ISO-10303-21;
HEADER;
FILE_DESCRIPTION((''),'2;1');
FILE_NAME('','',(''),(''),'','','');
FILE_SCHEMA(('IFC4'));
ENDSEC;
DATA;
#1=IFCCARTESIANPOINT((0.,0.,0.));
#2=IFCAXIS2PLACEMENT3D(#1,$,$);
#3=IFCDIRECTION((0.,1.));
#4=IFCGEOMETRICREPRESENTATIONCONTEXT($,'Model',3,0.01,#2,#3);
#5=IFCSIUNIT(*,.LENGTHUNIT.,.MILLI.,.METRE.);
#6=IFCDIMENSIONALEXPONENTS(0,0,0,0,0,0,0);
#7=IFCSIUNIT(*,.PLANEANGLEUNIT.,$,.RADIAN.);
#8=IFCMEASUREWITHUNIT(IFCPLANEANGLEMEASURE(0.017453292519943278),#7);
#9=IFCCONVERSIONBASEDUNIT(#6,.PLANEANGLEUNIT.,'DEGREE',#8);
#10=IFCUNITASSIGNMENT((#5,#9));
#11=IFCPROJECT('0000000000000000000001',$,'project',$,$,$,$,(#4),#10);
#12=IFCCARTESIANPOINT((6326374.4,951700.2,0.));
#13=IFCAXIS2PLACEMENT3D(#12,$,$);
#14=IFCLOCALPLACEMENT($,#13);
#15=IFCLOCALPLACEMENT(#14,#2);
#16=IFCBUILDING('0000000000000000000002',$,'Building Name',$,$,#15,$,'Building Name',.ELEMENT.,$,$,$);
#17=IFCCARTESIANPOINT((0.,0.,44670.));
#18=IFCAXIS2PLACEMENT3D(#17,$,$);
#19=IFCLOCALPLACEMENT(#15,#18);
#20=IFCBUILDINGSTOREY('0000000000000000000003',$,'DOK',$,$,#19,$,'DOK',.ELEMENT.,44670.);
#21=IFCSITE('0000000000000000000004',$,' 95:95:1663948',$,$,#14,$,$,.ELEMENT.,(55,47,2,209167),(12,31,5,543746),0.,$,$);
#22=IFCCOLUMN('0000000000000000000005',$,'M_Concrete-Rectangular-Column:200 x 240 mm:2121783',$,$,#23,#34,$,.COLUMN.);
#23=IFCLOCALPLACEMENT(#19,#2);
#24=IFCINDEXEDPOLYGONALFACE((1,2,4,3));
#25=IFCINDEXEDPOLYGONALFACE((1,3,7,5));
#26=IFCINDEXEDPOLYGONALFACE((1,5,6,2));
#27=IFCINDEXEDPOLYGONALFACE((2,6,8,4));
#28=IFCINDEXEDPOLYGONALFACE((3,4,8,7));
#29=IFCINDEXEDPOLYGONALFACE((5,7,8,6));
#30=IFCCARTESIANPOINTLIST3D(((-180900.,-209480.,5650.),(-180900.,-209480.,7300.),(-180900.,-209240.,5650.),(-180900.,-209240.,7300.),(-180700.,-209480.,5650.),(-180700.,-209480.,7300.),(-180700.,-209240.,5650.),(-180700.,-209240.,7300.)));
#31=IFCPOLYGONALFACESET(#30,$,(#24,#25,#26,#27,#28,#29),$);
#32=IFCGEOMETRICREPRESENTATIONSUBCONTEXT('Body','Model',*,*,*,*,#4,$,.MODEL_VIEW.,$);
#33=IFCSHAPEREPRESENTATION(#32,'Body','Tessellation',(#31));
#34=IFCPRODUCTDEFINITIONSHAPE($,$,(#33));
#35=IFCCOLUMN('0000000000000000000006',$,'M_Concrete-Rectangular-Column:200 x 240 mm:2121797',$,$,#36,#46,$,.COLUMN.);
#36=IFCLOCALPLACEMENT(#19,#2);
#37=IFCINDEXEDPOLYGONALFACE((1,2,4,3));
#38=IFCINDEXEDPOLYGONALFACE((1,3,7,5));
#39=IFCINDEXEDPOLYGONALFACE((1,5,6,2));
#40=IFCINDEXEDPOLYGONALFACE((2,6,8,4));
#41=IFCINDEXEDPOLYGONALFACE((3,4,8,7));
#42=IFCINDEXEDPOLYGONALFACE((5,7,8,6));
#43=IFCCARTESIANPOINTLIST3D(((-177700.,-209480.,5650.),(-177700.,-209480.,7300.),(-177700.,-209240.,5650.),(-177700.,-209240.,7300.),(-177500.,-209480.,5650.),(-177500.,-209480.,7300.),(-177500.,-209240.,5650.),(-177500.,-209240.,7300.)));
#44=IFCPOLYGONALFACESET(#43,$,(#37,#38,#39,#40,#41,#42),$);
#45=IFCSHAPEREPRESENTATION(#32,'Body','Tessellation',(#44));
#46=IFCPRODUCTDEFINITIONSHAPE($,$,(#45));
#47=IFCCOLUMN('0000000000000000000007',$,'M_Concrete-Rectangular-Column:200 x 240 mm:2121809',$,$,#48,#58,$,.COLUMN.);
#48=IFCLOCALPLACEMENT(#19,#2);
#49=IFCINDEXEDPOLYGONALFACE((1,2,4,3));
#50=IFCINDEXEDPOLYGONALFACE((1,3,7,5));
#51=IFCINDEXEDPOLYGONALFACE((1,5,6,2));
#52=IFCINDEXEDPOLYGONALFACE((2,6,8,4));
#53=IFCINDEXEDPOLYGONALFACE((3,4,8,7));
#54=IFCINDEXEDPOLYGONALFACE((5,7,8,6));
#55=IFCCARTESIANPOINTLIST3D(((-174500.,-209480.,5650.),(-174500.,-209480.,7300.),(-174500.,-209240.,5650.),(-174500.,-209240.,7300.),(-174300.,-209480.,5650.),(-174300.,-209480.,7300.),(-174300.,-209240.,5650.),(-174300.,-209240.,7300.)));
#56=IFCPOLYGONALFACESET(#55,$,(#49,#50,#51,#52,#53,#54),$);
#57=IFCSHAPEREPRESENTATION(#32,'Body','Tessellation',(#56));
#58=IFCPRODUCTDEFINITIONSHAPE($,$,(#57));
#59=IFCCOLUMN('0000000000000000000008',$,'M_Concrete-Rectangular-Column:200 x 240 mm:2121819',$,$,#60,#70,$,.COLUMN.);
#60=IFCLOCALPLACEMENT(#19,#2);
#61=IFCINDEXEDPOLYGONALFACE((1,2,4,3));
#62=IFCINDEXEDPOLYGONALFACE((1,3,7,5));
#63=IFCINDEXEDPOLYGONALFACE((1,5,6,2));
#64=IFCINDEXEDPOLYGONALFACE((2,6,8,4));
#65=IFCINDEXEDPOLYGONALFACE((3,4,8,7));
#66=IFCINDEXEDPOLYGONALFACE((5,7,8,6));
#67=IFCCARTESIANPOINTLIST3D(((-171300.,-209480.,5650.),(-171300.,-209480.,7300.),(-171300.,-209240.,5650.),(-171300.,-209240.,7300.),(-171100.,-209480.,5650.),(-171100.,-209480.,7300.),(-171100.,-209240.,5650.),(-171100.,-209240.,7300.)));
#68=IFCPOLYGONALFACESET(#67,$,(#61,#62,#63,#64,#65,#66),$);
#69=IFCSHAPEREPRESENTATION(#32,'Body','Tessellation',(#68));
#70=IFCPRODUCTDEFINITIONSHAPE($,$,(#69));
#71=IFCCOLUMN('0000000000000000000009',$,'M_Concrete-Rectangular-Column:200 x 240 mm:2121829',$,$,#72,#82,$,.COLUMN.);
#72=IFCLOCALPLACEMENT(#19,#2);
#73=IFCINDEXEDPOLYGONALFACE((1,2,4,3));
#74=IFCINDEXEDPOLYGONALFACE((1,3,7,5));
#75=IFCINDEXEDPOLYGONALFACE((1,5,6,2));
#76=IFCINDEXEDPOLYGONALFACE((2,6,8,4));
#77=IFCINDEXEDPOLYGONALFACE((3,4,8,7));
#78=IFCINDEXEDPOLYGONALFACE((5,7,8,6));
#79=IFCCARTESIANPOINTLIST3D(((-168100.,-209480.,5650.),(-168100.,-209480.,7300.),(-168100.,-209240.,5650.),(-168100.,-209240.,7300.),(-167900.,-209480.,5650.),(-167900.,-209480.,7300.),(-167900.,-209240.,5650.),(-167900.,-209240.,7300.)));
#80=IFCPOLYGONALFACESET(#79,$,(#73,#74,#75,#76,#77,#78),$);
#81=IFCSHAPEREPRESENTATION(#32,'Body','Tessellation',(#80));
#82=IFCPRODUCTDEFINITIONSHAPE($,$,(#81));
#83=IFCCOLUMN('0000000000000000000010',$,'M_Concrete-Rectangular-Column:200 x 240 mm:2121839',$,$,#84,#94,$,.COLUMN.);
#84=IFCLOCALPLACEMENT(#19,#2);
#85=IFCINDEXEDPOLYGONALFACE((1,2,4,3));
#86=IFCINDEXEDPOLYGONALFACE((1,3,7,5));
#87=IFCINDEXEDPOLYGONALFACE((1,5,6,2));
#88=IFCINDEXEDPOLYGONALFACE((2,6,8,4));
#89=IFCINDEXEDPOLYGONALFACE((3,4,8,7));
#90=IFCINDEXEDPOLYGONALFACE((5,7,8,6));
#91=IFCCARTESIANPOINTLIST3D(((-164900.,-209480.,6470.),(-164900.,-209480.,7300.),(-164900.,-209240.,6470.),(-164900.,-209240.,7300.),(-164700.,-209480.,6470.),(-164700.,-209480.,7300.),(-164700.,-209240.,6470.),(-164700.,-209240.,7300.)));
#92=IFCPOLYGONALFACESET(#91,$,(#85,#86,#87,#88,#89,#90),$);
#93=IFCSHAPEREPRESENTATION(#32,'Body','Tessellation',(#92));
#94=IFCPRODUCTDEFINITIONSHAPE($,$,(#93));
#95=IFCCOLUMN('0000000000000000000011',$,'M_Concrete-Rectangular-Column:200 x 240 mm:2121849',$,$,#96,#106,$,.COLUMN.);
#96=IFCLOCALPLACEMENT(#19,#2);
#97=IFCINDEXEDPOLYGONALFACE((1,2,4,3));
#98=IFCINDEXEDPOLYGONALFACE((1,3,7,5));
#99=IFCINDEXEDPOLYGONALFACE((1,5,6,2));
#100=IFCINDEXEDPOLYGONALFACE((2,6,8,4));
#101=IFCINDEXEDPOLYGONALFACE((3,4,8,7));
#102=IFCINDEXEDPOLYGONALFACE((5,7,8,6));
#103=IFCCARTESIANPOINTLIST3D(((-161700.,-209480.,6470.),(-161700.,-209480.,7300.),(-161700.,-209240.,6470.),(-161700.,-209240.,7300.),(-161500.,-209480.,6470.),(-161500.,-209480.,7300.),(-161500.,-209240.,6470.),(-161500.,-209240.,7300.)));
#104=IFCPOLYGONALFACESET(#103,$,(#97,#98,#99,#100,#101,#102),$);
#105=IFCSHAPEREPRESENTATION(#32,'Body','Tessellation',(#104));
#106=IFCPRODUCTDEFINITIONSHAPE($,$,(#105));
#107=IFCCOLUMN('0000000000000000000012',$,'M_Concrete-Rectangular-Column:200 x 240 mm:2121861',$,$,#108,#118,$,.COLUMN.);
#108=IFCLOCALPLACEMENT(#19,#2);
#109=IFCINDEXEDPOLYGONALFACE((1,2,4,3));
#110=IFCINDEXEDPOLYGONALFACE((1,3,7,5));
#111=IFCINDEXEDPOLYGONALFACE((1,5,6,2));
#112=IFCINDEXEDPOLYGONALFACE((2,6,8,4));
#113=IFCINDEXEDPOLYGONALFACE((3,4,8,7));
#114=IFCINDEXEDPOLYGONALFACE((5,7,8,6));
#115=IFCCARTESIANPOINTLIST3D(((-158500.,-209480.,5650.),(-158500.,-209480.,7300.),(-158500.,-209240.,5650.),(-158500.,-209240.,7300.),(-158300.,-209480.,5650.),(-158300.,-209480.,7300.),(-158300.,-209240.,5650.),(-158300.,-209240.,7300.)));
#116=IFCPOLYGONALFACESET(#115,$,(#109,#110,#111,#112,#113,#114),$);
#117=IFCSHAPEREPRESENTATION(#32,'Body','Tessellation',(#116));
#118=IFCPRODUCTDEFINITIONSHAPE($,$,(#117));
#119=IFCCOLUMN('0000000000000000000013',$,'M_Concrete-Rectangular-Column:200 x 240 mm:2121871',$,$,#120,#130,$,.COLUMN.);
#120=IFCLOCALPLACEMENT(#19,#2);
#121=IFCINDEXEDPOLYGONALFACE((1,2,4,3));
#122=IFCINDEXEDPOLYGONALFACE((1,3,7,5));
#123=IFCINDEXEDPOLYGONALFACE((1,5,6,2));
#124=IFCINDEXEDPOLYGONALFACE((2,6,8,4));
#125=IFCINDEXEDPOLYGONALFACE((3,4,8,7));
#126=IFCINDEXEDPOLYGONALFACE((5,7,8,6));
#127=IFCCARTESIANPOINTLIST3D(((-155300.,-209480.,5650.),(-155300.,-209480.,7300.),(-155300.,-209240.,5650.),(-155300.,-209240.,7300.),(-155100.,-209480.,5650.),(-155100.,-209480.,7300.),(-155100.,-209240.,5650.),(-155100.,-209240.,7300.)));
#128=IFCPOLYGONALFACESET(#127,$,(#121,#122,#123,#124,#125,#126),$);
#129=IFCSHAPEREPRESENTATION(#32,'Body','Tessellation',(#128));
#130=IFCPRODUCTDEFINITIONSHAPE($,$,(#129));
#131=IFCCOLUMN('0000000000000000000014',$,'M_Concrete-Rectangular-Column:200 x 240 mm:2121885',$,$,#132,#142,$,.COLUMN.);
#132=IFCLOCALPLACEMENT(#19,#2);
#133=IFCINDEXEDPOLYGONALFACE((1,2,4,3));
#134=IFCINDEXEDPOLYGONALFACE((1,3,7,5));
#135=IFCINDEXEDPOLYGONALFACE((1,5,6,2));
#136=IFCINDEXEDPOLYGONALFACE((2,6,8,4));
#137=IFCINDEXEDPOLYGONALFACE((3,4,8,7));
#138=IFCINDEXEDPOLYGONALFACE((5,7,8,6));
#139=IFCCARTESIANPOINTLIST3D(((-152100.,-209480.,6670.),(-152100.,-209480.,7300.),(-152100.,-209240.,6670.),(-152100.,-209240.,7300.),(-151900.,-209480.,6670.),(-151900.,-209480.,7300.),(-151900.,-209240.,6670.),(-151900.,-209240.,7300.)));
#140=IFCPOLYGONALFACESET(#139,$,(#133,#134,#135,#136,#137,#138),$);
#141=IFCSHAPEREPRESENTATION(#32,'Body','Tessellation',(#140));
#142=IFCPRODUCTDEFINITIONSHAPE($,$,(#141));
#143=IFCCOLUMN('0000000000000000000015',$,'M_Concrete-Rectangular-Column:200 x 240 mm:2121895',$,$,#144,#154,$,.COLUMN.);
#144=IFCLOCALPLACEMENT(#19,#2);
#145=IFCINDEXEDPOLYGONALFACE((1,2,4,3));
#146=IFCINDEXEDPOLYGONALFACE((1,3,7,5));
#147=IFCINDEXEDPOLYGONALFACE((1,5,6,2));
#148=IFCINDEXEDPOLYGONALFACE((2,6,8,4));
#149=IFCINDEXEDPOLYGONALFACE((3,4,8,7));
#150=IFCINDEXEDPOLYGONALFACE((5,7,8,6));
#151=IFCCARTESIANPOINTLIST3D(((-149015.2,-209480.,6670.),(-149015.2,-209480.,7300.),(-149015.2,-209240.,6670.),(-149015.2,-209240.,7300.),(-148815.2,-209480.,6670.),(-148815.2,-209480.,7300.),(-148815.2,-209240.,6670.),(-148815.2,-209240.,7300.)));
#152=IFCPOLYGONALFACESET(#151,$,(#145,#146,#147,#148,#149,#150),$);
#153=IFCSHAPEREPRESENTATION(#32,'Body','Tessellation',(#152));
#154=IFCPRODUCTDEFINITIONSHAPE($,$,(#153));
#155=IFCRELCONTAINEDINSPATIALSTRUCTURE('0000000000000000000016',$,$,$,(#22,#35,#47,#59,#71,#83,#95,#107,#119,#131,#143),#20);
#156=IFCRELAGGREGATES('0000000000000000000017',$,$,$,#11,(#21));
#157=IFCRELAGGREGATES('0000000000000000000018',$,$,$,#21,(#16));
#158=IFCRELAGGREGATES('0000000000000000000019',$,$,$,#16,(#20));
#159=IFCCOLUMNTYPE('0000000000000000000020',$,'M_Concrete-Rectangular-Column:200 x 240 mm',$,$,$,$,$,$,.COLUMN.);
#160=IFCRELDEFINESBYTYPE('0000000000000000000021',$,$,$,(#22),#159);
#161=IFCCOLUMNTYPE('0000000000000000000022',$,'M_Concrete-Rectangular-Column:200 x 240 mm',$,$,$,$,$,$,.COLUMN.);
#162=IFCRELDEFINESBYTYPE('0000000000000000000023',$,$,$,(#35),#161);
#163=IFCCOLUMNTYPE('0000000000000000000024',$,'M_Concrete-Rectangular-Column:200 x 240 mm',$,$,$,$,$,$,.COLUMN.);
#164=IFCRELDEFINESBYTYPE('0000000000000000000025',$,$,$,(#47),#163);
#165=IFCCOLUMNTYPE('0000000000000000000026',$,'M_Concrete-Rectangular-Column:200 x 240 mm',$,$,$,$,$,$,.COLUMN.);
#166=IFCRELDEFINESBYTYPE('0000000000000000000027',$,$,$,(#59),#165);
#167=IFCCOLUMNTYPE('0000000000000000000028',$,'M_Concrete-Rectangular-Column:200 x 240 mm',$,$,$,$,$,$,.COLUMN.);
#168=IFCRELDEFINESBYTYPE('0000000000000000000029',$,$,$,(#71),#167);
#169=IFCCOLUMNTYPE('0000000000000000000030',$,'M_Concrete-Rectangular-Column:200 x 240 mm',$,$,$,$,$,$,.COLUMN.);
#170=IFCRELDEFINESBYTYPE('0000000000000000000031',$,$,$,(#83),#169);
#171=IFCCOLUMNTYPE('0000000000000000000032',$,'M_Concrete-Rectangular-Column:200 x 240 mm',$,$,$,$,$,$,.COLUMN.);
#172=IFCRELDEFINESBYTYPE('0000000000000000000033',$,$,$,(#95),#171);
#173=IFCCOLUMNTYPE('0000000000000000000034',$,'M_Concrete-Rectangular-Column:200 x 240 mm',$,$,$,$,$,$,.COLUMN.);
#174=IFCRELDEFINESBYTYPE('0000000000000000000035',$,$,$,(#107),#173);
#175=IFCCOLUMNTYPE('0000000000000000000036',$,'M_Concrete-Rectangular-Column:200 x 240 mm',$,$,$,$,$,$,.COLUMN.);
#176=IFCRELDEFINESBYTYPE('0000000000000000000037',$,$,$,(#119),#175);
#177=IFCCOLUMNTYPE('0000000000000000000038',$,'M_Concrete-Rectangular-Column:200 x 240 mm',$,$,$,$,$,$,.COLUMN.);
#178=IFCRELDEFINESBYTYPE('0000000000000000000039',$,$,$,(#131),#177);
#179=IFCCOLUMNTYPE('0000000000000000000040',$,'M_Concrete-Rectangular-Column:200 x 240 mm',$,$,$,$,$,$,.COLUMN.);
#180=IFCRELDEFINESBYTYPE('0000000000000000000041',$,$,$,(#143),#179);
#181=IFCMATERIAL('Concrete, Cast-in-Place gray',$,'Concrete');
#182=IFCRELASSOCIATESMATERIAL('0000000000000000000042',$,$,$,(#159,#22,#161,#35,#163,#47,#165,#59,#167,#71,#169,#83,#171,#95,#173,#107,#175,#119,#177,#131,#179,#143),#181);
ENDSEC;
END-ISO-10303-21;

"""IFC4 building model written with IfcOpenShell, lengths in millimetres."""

from ifc_helpers import new_model, entity, si_unit, converted_unit, direction, frame, origin, place, context, subcontext, project, spatial, indexed_curve, outline, extrude, source, transform, mapped, material, type_object, type_shapes, element, save


model = new_model("IFC4")

# Units and contexts
model_context = context("Model", 3, precision=0.01, world=origin(), true_north=direction((0.0, 1.0)))
body_context = subcontext(model_context, "Body", "Model", "MODEL_VIEW")
ifc_project = project(units=[si_unit("LENGTHUNIT", "METRE", prefix="MILLI"), converted_unit("PLANEANGLEUNIT", "DEGREE", entity("IfcPlaneAngleMeasure", 0.017453292519943278), si_unit("PLANEANGLEUNIT", "RADIAN"), dimensions=[0, 0, 0, 0, 0, 0, 0])], contexts=[model_context])

# Site, building, storey
site_placement = place(None, frame((6326374.4, 951700.2, 0.0)))
site = spatial("IfcSite", under=ifc_project, at=site_placement, Name=" 95:95:1663948", CompositionType="ELEMENT", RefLatitude=(55, 47, 2, 209167), RefLongitude=(12, 31, 5, 543746), RefElevation=0.0)
building_placement = place(site_placement, origin())
building = spatial("IfcBuilding", under=site, at=building_placement, Name="Building Name", LongName="Building Name", CompositionType="ELEMENT")
storey_placement = place(building_placement, frame((0.0, 0.0, 44670.0)))
storey = spatial("IfcBuildingStorey", under=building, at=storey_placement, Name="DOK", LongName="DOK", CompositionType="ELEMENT", Elevation=44670.0)

# Columns
ifc_material = material(Name="Concrete, Cast-in-Place gray", Category="Concrete")
column_type_1 = type_object("IfcColumnType", Name="M_Concrete-Rectangular-Column:200 x 240 mm", PredefinedType="COLUMN", material=ifc_material)
shared_shape_1 = source(origin(), body_context, "Body", "SweptSolid", [
    extrude(outline(indexed_curve([(-100.0, -120.0), (100.0, -120.0), (100.0, 120.0), (-100.0, 120.0), (-100.0, -120.0)], self_intersect=False)), frame((-180800.0, -209360.0, 50320.0), z_axis=(0.0, 0.0, 1.0), x_axis=(-1.0, 0.0, 0.0)), (0.0, 0.0, 1.0), 1650.0),
])
type_shapes(column_type_1, [shared_shape_1])
column_1_placement = place(storey_placement, frame((0.0, 0.0, -44670.0)))
element("IfcColumn", 1, at=column_1_placement, inside=storey, type_object=column_type_1, material=ifc_material, Name="M_Concrete-Rectangular-Column:200 x 240 mm:2121783", PredefinedType="COLUMN", context=body_context, shape_type="MappedRepresentation", body=[
    mapped(shared_shape_1, transform((0.0, 0.0, 0.0), scale=1.0)),
])
column_type_2 = type_object("IfcColumnType", Name="M_Concrete-Rectangular-Column:200 x 240 mm", PredefinedType="COLUMN", material=ifc_material)
shared_shape_2 = source(origin(), body_context, "Body", "SweptSolid", [
    extrude(outline(indexed_curve([(-100.0, -120.0), (100.0, -120.0), (100.0, 120.0), (-100.0, 120.0), (-100.0, -120.0)], self_intersect=False)), frame((-177600.0, -209360.0, 50320.0), z_axis=(0.0, 0.0, 1.0), x_axis=(-1.0, 0.0, 0.0)), (0.0, 0.0, 1.0), 1650.0),
])
type_shapes(column_type_2, [shared_shape_2])
column_2_placement = place(storey_placement, frame((0.0, 0.0, -44670.0)))
element("IfcColumn", 2, at=column_2_placement, inside=storey, type_object=column_type_2, material=ifc_material, Name="M_Concrete-Rectangular-Column:200 x 240 mm:2121797", PredefinedType="COLUMN", context=body_context, shape_type="MappedRepresentation", body=[
    mapped(shared_shape_2, transform((0.0, 0.0, 0.0), scale=1.0)),
])
column_type_3 = type_object("IfcColumnType", Name="M_Concrete-Rectangular-Column:200 x 240 mm", PredefinedType="COLUMN", material=ifc_material)
shared_shape_3 = source(origin(), body_context, "Body", "SweptSolid", [
    extrude(outline(indexed_curve([(-100.0, -120.0), (100.0, -120.0), (100.0, 120.0), (-100.0, 120.0), (-100.0, -120.0)], self_intersect=False)), frame((-174400.0, -209360.0, 50320.0), z_axis=(0.0, 0.0, 1.0), x_axis=(-1.0, 0.0, 0.0)), (0.0, 0.0, 1.0), 1650.0),
])
type_shapes(column_type_3, [shared_shape_3])
column_3_placement = place(storey_placement, frame((0.0, 0.0, -44670.0)))
element("IfcColumn", 3, at=column_3_placement, inside=storey, type_object=column_type_3, material=ifc_material, Name="M_Concrete-Rectangular-Column:200 x 240 mm:2121809", PredefinedType="COLUMN", context=body_context, shape_type="MappedRepresentation", body=[
    mapped(shared_shape_3, transform((0.0, 0.0, 0.0), scale=1.0)),
])
column_type_4 = type_object("IfcColumnType", Name="M_Concrete-Rectangular-Column:200 x 240 mm", PredefinedType="COLUMN", material=ifc_material)
shared_shape_4 = source(origin(), body_context, "Body", "SweptSolid", [
    extrude(outline(indexed_curve([(-100.0, -120.0), (100.0, -120.0), (100.0, 120.0), (-100.0, 120.0), (-100.0, -120.0)], self_intersect=False)), frame((-171200.0, -209360.0, 50320.0), z_axis=(0.0, 0.0, 1.0), x_axis=(-1.0, 0.0, 0.0)), (0.0, 0.0, 1.0), 1650.0),
])
type_shapes(column_type_4, [shared_shape_4])
column_4_placement = place(storey_placement, frame((0.0, 0.0, -44670.0)))
element("IfcColumn", 4, at=column_4_placement, inside=storey, type_object=column_type_4, material=ifc_material, Name="M_Concrete-Rectangular-Column:200 x 240 mm:2121819", PredefinedType="COLUMN", context=body_context, shape_type="MappedRepresentation", body=[
    mapped(shared_shape_4, transform((0.0, 0.0, 0.0), scale=1.0)),
])
column_type_5 = type_object("IfcColumnType", Name="M_Concrete-Rectangular-Column:200 x 240 mm", PredefinedType="COLUMN", material=ifc_material)
shared_shape_5 = source(origin(), body_context, "Body", "SweptSolid", [
    extrude(outline(indexed_curve([(-100.0, -120.0), (100.0, -120.0), (100.0, 120.0), (-100.0, 120.0), (-100.0, -120.0)], self_intersect=False)), frame((-168000.0, -209360.0, 50320.0), z_axis=(0.0, 0.0, 1.0), x_axis=(-1.0, 0.0, 0.0)), (0.0, 0.0, 1.0), 1650.0),
])
type_shapes(column_type_5, [shared_shape_5])
column_5_placement = place(storey_placement, frame((0.0, 0.0, -44670.0)))
element("IfcColumn", 5, at=column_5_placement, inside=storey, type_object=column_type_5, material=ifc_material, Name="M_Concrete-Rectangular-Column:200 x 240 mm:2121829", PredefinedType="COLUMN", context=body_context, shape_type="MappedRepresentation", body=[
    mapped(shared_shape_5, transform((0.0, 0.0, 0.0), scale=1.0)),
])
column_type_6 = type_object("IfcColumnType", Name="M_Concrete-Rectangular-Column:200 x 240 mm", PredefinedType="COLUMN", material=ifc_material)
shared_shape_6 = source(origin(), body_context, "Body", "SweptSolid", [
    extrude(outline(indexed_curve([(-100.0, -120.0), (100.0, -120.0), (100.0, 120.0), (-100.0, 120.0), (-100.0, -120.0)], self_intersect=False)), frame((-164800.0, -209360.0, 51140.0), z_axis=(0.0, 0.0, 1.0), x_axis=(-1.0, 0.0, 0.0)), (0.0, 0.0, 1.0), 830.0),
])
type_shapes(column_type_6, [shared_shape_6])
column_6_placement = place(storey_placement, frame((0.0, 0.0, -44670.0)))
element("IfcColumn", 6, at=column_6_placement, inside=storey, type_object=column_type_6, material=ifc_material, Name="M_Concrete-Rectangular-Column:200 x 240 mm:2121839", PredefinedType="COLUMN", context=body_context, shape_type="MappedRepresentation", body=[
    mapped(shared_shape_6, transform((0.0, 0.0, 0.0), scale=1.0)),
])
column_type_7 = type_object("IfcColumnType", Name="M_Concrete-Rectangular-Column:200 x 240 mm", PredefinedType="COLUMN", material=ifc_material)
shared_shape_7 = source(origin(), body_context, "Body", "SweptSolid", [
    extrude(outline(indexed_curve([(-100.0, -120.0), (100.0, -120.0), (100.0, 120.0), (-100.0, 120.0), (-100.0, -120.0)], self_intersect=False)), frame((-161600.0, -209360.0, 51140.0), z_axis=(0.0, 0.0, 1.0), x_axis=(-1.0, 0.0, 0.0)), (0.0, 0.0, 1.0), 830.0),
])
type_shapes(column_type_7, [shared_shape_7])
column_7_placement = place(storey_placement, frame((0.0, 0.0, -44670.0)))
element("IfcColumn", 7, at=column_7_placement, inside=storey, type_object=column_type_7, material=ifc_material, Name="M_Concrete-Rectangular-Column:200 x 240 mm:2121849", PredefinedType="COLUMN", context=body_context, shape_type="MappedRepresentation", body=[
    mapped(shared_shape_7, transform((0.0, 0.0, 0.0), scale=1.0)),
])
column_type_8 = type_object("IfcColumnType", Name="M_Concrete-Rectangular-Column:200 x 240 mm", PredefinedType="COLUMN", material=ifc_material)
shared_shape_8 = source(origin(), body_context, "Body", "SweptSolid", [
    extrude(outline(indexed_curve([(-100.0, -120.0), (100.0, -120.0), (100.0, 120.0), (-100.0, 120.0), (-100.0, -120.0)], self_intersect=False)), frame((-158400.0, -209360.0, 50320.0), z_axis=(0.0, 0.0, 1.0), x_axis=(-1.0, 0.0, 0.0)), (0.0, 0.0, 1.0), 1650.0),
])
type_shapes(column_type_8, [shared_shape_8])
column_8_placement = place(storey_placement, frame((0.0, 0.0, -44670.0)))
element("IfcColumn", 8, at=column_8_placement, inside=storey, type_object=column_type_8, material=ifc_material, Name="M_Concrete-Rectangular-Column:200 x 240 mm:2121861", PredefinedType="COLUMN", context=body_context, shape_type="MappedRepresentation", body=[
    mapped(shared_shape_8, transform((0.0, 0.0, 0.0), scale=1.0)),
])
column_type_9 = type_object("IfcColumnType", Name="M_Concrete-Rectangular-Column:200 x 240 mm", PredefinedType="COLUMN", material=ifc_material)
shared_shape_9 = source(origin(), body_context, "Body", "SweptSolid", [
    extrude(outline(indexed_curve([(-100.0, -120.0), (100.0, -120.0), (100.0, 120.0), (-100.0, 120.0), (-100.0, -120.0)], self_intersect=False)), frame((-155200.0, -209360.0, 50320.0), z_axis=(0.0, 0.0, 1.0), x_axis=(-1.0, 0.0, 0.0)), (0.0, 0.0, 1.0), 1650.0),
])
type_shapes(column_type_9, [shared_shape_9])
column_9_placement = place(storey_placement, frame((0.0, 0.0, -44670.0)))
element("IfcColumn", 9, at=column_9_placement, inside=storey, type_object=column_type_9, material=ifc_material, Name="M_Concrete-Rectangular-Column:200 x 240 mm:2121871", PredefinedType="COLUMN", context=body_context, shape_type="MappedRepresentation", body=[
    mapped(shared_shape_9, transform((0.0, 0.0, 0.0), scale=1.0)),
])
column_type_10 = type_object("IfcColumnType", Name="M_Concrete-Rectangular-Column:200 x 240 mm", PredefinedType="COLUMN", material=ifc_material)
shared_shape_10 = source(origin(), body_context, "Body", "SweptSolid", [
    extrude(outline(indexed_curve([(-100.0, -120.0), (100.0, -120.0), (100.0, 120.0), (-100.0, 120.0), (-100.0, -120.0)], self_intersect=False)), frame((-152000.0, -209360.0, 51340.0), z_axis=(0.0, 0.0, 1.0), x_axis=(-1.0, 0.0, 0.0)), (0.0, 0.0, 1.0), 630.0),
])
type_shapes(column_type_10, [shared_shape_10])
column_10_placement = place(storey_placement, frame((0.0, 0.0, -44670.0)))
element("IfcColumn", 10, at=column_10_placement, inside=storey, type_object=column_type_10, material=ifc_material, Name="M_Concrete-Rectangular-Column:200 x 240 mm:2121885", PredefinedType="COLUMN", context=body_context, shape_type="MappedRepresentation", body=[
    mapped(shared_shape_10, transform((0.0, 0.0, 0.0), scale=1.0)),
])
column_type_11 = type_object("IfcColumnType", Name="M_Concrete-Rectangular-Column:200 x 240 mm", PredefinedType="COLUMN", material=ifc_material)
shared_shape_11 = source(origin(), body_context, "Body", "SweptSolid", [
    extrude(outline(indexed_curve([(-100.0, -120.0), (100.0, -120.0), (100.0, 120.0), (-100.0, 120.0), (-100.0, -120.0)], self_intersect=False)), frame((-148915.2, -209360.0, 51340.0), z_axis=(0.0, 0.0, 1.0), x_axis=(-1.0, 0.0, 0.0)), (0.0, 0.0, 1.0), 630.0),
])
type_shapes(column_type_11, [shared_shape_11])
column_11_placement = place(storey_placement, frame((0.0, 0.0, -44670.0)))
element("IfcColumn", 11, at=column_11_placement, inside=storey, type_object=column_type_11, material=ifc_material, Name="M_Concrete-Rectangular-Column:200 x 240 mm:2121895", PredefinedType="COLUMN", context=body_context, shape_type="MappedRepresentation", body=[
    mapped(shared_shape_11, transform((0.0, 0.0, 0.0), scale=1.0)),
])

save(model, "model.ifc")
